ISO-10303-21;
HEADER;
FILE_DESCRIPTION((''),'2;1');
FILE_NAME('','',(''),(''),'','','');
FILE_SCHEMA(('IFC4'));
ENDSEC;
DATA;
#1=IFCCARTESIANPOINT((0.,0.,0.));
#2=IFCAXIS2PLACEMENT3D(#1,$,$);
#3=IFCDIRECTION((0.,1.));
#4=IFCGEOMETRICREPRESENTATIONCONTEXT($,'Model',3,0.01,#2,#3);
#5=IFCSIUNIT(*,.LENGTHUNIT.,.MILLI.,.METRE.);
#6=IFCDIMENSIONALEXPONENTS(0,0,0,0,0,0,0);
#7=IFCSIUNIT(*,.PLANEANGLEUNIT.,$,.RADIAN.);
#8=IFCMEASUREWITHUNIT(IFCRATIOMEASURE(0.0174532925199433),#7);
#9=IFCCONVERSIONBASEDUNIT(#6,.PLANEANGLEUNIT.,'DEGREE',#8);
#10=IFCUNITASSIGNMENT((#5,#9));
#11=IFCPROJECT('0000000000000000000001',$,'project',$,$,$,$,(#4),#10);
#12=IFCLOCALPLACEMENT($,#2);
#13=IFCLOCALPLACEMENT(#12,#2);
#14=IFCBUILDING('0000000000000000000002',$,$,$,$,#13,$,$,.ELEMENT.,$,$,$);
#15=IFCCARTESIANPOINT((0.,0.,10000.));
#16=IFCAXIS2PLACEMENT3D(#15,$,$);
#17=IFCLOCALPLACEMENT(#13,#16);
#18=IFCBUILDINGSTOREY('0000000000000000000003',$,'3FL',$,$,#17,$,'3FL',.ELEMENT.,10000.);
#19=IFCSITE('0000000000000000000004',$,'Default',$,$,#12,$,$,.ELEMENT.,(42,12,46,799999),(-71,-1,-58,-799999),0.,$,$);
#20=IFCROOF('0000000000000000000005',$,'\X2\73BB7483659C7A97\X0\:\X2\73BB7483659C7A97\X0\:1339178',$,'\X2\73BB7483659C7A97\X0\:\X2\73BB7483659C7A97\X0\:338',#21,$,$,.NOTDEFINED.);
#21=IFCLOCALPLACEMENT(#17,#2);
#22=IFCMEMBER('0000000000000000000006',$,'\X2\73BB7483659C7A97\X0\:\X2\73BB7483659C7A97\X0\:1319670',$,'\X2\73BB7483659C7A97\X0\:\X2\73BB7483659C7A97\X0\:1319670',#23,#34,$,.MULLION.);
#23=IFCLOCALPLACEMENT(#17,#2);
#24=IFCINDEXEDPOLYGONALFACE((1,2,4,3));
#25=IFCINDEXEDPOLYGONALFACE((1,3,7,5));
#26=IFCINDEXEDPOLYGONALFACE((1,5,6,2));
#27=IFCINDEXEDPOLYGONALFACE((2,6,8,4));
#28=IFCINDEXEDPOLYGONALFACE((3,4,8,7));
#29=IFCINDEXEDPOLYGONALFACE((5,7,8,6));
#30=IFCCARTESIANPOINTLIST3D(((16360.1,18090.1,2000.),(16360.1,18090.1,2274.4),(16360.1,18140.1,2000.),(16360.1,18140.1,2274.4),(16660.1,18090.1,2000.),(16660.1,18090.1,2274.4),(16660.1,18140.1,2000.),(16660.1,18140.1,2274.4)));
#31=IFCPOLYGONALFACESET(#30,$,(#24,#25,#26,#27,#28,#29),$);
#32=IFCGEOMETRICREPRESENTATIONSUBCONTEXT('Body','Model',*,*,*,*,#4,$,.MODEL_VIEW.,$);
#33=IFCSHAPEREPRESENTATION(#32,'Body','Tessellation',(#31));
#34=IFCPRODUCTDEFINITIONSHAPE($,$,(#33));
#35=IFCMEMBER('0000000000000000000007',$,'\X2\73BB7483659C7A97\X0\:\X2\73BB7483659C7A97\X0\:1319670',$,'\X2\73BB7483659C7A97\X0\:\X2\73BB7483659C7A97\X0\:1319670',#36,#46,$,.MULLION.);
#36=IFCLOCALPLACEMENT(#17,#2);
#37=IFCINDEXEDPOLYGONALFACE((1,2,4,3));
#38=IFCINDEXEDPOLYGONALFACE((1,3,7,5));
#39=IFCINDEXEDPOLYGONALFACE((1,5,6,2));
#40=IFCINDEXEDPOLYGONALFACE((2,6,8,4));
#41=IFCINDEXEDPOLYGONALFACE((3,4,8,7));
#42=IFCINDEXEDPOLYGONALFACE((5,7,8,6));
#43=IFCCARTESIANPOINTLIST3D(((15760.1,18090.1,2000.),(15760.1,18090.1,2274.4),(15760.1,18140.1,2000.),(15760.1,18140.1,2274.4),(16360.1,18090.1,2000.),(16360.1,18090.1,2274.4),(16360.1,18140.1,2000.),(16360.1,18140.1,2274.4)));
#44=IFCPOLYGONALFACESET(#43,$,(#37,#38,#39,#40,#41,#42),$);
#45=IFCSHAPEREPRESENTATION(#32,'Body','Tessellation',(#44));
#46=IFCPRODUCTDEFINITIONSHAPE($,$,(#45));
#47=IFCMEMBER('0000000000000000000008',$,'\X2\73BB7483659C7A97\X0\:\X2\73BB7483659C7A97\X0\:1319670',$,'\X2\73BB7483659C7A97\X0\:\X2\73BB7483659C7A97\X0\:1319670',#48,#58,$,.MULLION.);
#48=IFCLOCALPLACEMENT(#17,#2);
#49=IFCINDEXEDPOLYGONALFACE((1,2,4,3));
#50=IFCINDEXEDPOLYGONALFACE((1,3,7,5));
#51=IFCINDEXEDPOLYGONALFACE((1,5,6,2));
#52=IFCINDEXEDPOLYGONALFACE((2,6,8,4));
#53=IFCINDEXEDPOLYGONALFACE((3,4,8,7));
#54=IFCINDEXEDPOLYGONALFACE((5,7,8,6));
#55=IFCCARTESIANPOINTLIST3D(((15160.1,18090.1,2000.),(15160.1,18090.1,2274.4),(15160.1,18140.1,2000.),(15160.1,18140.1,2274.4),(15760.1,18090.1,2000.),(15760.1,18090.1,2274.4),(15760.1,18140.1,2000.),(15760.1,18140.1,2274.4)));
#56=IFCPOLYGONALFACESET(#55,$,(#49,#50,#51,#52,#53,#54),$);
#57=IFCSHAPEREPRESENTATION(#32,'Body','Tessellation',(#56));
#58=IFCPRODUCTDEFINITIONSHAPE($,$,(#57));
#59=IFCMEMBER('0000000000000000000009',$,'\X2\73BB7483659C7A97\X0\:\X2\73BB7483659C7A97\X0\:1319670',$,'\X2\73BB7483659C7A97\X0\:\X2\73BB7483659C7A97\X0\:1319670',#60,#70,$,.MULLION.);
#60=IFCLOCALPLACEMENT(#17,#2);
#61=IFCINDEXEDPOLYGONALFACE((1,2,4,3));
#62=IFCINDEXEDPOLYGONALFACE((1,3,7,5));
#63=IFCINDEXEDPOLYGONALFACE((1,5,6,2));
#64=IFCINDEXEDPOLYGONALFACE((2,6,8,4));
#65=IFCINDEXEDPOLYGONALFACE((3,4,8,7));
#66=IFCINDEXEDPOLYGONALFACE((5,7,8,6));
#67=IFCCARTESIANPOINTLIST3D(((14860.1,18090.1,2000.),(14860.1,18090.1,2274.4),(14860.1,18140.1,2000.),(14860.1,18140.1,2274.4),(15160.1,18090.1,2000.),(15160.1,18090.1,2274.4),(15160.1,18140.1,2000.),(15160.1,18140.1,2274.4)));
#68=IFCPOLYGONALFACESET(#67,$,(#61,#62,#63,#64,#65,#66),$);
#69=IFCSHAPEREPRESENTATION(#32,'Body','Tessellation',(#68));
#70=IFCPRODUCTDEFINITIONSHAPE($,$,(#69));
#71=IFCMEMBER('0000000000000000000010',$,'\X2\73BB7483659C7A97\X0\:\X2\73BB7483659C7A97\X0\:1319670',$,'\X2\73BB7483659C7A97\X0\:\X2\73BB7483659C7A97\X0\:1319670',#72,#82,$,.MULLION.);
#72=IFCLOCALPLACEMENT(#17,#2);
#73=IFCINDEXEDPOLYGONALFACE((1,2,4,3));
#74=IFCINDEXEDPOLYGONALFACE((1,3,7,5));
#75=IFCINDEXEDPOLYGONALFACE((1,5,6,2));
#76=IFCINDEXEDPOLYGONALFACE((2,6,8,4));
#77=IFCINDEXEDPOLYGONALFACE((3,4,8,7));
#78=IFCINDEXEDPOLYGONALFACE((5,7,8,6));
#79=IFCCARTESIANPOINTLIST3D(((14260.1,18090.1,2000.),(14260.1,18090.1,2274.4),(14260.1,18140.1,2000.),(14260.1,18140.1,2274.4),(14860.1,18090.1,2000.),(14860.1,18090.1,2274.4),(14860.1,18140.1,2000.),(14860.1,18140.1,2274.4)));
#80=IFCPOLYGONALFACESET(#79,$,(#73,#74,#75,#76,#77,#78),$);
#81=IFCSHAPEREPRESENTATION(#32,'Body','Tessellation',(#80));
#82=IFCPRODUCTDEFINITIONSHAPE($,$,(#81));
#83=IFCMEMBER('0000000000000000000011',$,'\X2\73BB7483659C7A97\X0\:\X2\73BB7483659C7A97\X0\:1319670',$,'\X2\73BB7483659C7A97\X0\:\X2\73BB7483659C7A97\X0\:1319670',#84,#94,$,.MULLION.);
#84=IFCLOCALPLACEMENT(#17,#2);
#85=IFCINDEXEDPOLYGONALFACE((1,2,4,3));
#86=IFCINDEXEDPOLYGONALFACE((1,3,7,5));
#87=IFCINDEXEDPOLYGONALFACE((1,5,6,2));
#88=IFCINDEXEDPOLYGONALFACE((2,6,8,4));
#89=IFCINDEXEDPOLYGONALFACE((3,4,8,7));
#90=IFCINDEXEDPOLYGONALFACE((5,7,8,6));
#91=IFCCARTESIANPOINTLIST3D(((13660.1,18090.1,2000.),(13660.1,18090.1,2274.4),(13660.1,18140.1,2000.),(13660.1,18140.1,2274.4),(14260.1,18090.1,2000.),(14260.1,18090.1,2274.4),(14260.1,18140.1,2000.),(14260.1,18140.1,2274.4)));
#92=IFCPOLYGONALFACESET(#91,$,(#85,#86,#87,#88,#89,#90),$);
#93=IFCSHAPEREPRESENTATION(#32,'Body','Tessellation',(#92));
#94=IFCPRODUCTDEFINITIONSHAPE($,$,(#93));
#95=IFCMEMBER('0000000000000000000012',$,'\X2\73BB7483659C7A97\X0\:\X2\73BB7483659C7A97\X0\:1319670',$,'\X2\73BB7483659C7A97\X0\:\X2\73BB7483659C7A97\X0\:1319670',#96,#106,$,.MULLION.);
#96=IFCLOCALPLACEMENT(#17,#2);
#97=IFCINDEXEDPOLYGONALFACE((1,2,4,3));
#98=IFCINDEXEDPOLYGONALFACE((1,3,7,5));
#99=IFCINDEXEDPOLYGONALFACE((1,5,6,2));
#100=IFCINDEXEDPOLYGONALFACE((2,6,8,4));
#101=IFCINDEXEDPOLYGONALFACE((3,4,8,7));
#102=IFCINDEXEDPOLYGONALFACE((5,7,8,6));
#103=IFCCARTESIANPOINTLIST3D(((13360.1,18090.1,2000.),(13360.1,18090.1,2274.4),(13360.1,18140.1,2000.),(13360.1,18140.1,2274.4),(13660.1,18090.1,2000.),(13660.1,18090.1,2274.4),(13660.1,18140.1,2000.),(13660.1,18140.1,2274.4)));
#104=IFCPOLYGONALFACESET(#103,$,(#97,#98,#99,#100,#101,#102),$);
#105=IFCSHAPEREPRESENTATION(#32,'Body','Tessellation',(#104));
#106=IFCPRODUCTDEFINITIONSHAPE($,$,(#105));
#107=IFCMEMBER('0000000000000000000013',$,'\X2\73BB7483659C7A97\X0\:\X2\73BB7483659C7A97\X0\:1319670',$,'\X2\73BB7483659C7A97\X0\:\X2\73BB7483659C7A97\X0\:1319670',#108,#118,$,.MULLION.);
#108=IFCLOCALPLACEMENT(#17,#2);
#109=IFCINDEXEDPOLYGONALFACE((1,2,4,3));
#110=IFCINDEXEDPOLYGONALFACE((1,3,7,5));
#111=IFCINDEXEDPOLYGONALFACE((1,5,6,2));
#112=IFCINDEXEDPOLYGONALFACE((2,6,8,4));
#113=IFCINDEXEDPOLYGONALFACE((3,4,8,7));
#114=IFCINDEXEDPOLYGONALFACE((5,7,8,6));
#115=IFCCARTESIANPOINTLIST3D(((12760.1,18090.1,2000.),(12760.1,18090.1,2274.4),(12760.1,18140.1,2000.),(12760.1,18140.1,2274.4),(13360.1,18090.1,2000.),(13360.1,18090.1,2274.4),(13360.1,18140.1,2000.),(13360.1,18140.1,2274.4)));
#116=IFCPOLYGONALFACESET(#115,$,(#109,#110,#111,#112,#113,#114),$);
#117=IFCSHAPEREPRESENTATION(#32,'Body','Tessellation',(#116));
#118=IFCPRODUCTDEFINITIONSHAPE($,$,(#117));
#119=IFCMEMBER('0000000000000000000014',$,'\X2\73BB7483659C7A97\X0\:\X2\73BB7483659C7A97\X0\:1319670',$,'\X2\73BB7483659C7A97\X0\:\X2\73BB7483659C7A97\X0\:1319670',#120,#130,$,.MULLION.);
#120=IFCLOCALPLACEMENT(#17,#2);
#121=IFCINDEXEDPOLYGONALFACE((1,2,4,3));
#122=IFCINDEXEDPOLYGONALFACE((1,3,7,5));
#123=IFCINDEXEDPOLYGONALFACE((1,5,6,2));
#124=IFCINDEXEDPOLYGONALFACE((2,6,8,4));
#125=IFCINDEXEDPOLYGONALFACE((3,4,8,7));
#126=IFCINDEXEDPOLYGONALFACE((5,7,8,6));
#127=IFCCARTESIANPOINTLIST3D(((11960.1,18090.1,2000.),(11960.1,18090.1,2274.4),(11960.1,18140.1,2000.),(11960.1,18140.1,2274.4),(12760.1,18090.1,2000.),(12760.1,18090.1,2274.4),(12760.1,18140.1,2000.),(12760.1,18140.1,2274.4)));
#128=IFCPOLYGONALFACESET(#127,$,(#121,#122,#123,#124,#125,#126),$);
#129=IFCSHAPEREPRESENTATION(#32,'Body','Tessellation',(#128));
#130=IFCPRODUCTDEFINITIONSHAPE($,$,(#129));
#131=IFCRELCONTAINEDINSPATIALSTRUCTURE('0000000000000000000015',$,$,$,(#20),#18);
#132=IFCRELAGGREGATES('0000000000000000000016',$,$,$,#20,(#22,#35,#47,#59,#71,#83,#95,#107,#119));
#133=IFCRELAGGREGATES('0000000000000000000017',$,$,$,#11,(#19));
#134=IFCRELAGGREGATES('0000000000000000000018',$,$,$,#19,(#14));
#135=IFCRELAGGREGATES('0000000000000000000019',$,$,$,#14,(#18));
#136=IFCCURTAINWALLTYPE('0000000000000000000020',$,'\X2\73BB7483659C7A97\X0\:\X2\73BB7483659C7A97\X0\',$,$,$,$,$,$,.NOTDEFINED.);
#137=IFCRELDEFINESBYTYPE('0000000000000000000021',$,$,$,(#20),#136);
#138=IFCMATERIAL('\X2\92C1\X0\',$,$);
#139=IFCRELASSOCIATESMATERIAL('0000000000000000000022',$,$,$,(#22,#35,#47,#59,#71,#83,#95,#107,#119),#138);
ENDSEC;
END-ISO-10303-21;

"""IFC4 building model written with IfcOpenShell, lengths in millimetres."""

from ifc_helpers import new_model, entity, si_unit, converted_unit, direction, frame, frame_2d, origin, place, context, subcontext, project, spatial, rectangle, extrude, material, type_object, element, aggregate, save


model = new_model("IFC4")

# Units and contexts
model_context = context("Model", 3, precision=0.01, world=origin(), true_north=direction((0.0, 1.0)))
body_context = subcontext(model_context, "Body", "Model", "MODEL_VIEW")
ifc_project = project(units=[si_unit("LENGTHUNIT", "METRE", prefix="MILLI"), converted_unit("PLANEANGLEUNIT", "DEGREE", entity("IfcRatioMeasure", 0.0174532925199433), si_unit("PLANEANGLEUNIT", "RADIAN"), dimensions=[0, 0, 0, 0, 0, 0, 0])], contexts=[model_context])

# Site, building, storey
site_placement = place(None, origin())
site = spatial("IfcSite", under=ifc_project, at=site_placement, Name="Default", CompositionType="ELEMENT", RefLatitude=(42, 12, 46, 799999), RefLongitude=(-71, -1, -58, -799999), RefElevation=0.0)
building_placement = place(site_placement, origin())
building = spatial("IfcBuilding", under=site, at=building_placement, CompositionType="ELEMENT")
storey_placement = place(building_placement, frame((0.0, 0.0, 10000.0)))
storey = spatial("IfcBuildingStorey", under=building, at=storey_placement, Name="3FL", LongName="3FL", CompositionType="ELEMENT", Elevation=10000.0)

# Roof, members
curtain_wall_type = type_object("IfcCurtainWallType", Name="玻璃斜窗:玻璃斜窗", PredefinedType="NOTDEFINED")
roof_placement = place(storey_placement, frame((0.0, 0.0, -10000.0)))
roof = element("IfcRoof", 1, at=roof_placement, inside=storey, type_object=curtain_wall_type, Name="玻璃斜窗:玻璃斜窗:1339178", ObjectType="玻璃斜窗:玻璃斜窗:338", PredefinedType="NOTDEFINED")
ifc_material = material(Name="鋁")
member_1_placement = place(roof_placement, frame((0.0, 0.0, 10000.0)))
member_1 = element("IfcMember", 2, at=member_1_placement, material=ifc_material, Name="玻璃斜窗:玻璃斜窗:1319670", ObjectType="玻璃斜窗:玻璃斜窗:1319670", PredefinedType="MULLION", context=body_context, shape_type="SweptSolid", body=[
    extrude(rectangle(XDim=274.5, YDim=50.0, at=frame_2d((0.0, 0.0), x_axis=(1.0, 0.0))), frame((16660.1, 18115.1, 2137.2), z_axis=(-1.0, 0.0, 0.0), x_axis=(0.0, 0.0, -1.0)), (0.0, 0.0, 1.0), 300.0),
])
member_2_placement = place(roof_placement, frame((0.0, 0.0, 10000.0)))
member_2 = element("IfcMember", 3, at=member_2_placement, material=ifc_material, Name="玻璃斜窗:玻璃斜窗:1319670", ObjectType="玻璃斜窗:玻璃斜窗:1319670", PredefinedType="MULLION", context=body_context, shape_type="SweptSolid", body=[
    extrude(rectangle(XDim=274.5, YDim=50.0, at=frame_2d((0.0, 0.0), x_axis=(1.0, 0.0))), frame((16360.1, 18115.1, 2137.2), z_axis=(-1.0, 0.0, 0.0), x_axis=(0.0, 0.0, -1.0)), (0.0, 0.0, 1.0), 600.0),
])
member_3_placement = place(roof_placement, frame((0.0, 0.0, 10000.0)))
member_3 = element("IfcMember", 4, at=member_3_placement, material=ifc_material, Name="玻璃斜窗:玻璃斜窗:1319670", ObjectType="玻璃斜窗:玻璃斜窗:1319670", PredefinedType="MULLION", context=body_context, shape_type="SweptSolid", body=[
    extrude(rectangle(XDim=274.5, YDim=50.0, at=frame_2d((0.0, 0.0), x_axis=(1.0, 0.0))), frame((15760.1, 18115.1, 2137.2), z_axis=(-1.0, 0.0, 0.0), x_axis=(0.0, 0.0, -1.0)), (0.0, 0.0, 1.0), 600.0),
])
member_4_placement = place(roof_placement, frame((0.0, 0.0, 10000.0)))
member_4 = element("IfcMember", 5, at=member_4_placement, material=ifc_material, Name="玻璃斜窗:玻璃斜窗:1319670", ObjectType="玻璃斜窗:玻璃斜窗:1319670", PredefinedType="MULLION", context=body_context, shape_type="SweptSolid", body=[
    extrude(rectangle(XDim=274.5, YDim=50.0, at=frame_2d((0.0, 0.0), x_axis=(1.0, 0.0))), frame((15160.1, 18115.1, 2137.2), z_axis=(-1.0, 0.0, 0.0), x_axis=(0.0, 0.0, -1.0)), (0.0, 0.0, 1.0), 300.0),
])
member_5_placement = place(roof_placement, frame((0.0, 0.0, 10000.0)))
member_5 = element("IfcMember", 6, at=member_5_placement, material=ifc_material, Name="玻璃斜窗:玻璃斜窗:1319670", ObjectType="玻璃斜窗:玻璃斜窗:1319670", PredefinedType="MULLION", context=body_context, shape_type="SweptSolid", body=[
    extrude(rectangle(XDim=274.5, YDim=50.0, at=frame_2d((0.0, 0.0), x_axis=(1.0, 0.0))), frame((14860.1, 18115.1, 2137.2), z_axis=(-1.0, 0.0, 0.0), x_axis=(0.0, 0.0, -1.0)), (0.0, 0.0, 1.0), 600.0),
])
member_6_placement = place(roof_placement, frame((0.0, 0.0, 10000.0)))
member_6 = element("IfcMember", 7, at=member_6_placement, material=ifc_material, Name="玻璃斜窗:玻璃斜窗:1319670", ObjectType="玻璃斜窗:玻璃斜窗:1319670", PredefinedType="MULLION", context=body_context, shape_type="SweptSolid", body=[
    extrude(rectangle(XDim=274.5, YDim=50.0, at=frame_2d((0.0, 0.0), x_axis=(1.0, 0.0))), frame((14260.1, 18115.1, 2137.2), z_axis=(-1.0, 0.0, 0.0), x_axis=(0.0, 0.0, -1.0)), (0.0, 0.0, 1.0), 600.0),
])
member_7_placement = place(roof_placement, frame((0.0, 0.0, 10000.0)))
member_7 = element("IfcMember", 8, at=member_7_placement, material=ifc_material, Name="玻璃斜窗:玻璃斜窗:1319670", ObjectType="玻璃斜窗:玻璃斜窗:1319670", PredefinedType="MULLION", context=body_context, shape_type="SweptSolid", body=[
    extrude(rectangle(XDim=274.5, YDim=50.0, at=frame_2d((0.0, 0.0), x_axis=(1.0, 0.0))), frame((13660.1, 18115.1, 2137.2), z_axis=(-1.0, 0.0, 0.0), x_axis=(0.0, 0.0, -1.0)), (0.0, 0.0, 1.0), 300.0),
])
member_8_placement = place(roof_placement, frame((0.0, 0.0, 10000.0)))
member_8 = element("IfcMember", 9, at=member_8_placement, material=ifc_material, Name="玻璃斜窗:玻璃斜窗:1319670", ObjectType="玻璃斜窗:玻璃斜窗:1319670", PredefinedType="MULLION", context=body_context, shape_type="SweptSolid", body=[
    extrude(rectangle(XDim=274.5, YDim=50.0, at=frame_2d((0.0, 0.0), x_axis=(1.0, 0.0))), frame((13360.1, 18115.1, 2137.2), z_axis=(-1.0, 0.0, 0.0), x_axis=(0.0, 0.0, -1.0)), (0.0, 0.0, 1.0), 600.0),
])
member_9_placement = place(roof_placement, frame((0.0, 0.0, 10000.0)))
member_9 = element("IfcMember", 10, at=member_9_placement, material=ifc_material, Name="玻璃斜窗:玻璃斜窗:1319670", ObjectType="玻璃斜窗:玻璃斜窗:1319670", PredefinedType="MULLION", context=body_context, shape_type="SweptSolid", body=[
    extrude(rectangle(XDim=274.5, YDim=50.0, at=frame_2d((0.0, 0.0), x_axis=(1.0, 0.0))), frame((12760.1, 18115.1, 2137.2), z_axis=(-1.0, 0.0, 0.0), x_axis=(0.0, 0.0, -1.0)), (0.0, 0.0, 1.0), 800.0),
])
aggregate(roof, [member_1, member_2, member_3, member_4, member_5, member_6, member_7, member_8, member_9])

save(model, "model.ifc")
